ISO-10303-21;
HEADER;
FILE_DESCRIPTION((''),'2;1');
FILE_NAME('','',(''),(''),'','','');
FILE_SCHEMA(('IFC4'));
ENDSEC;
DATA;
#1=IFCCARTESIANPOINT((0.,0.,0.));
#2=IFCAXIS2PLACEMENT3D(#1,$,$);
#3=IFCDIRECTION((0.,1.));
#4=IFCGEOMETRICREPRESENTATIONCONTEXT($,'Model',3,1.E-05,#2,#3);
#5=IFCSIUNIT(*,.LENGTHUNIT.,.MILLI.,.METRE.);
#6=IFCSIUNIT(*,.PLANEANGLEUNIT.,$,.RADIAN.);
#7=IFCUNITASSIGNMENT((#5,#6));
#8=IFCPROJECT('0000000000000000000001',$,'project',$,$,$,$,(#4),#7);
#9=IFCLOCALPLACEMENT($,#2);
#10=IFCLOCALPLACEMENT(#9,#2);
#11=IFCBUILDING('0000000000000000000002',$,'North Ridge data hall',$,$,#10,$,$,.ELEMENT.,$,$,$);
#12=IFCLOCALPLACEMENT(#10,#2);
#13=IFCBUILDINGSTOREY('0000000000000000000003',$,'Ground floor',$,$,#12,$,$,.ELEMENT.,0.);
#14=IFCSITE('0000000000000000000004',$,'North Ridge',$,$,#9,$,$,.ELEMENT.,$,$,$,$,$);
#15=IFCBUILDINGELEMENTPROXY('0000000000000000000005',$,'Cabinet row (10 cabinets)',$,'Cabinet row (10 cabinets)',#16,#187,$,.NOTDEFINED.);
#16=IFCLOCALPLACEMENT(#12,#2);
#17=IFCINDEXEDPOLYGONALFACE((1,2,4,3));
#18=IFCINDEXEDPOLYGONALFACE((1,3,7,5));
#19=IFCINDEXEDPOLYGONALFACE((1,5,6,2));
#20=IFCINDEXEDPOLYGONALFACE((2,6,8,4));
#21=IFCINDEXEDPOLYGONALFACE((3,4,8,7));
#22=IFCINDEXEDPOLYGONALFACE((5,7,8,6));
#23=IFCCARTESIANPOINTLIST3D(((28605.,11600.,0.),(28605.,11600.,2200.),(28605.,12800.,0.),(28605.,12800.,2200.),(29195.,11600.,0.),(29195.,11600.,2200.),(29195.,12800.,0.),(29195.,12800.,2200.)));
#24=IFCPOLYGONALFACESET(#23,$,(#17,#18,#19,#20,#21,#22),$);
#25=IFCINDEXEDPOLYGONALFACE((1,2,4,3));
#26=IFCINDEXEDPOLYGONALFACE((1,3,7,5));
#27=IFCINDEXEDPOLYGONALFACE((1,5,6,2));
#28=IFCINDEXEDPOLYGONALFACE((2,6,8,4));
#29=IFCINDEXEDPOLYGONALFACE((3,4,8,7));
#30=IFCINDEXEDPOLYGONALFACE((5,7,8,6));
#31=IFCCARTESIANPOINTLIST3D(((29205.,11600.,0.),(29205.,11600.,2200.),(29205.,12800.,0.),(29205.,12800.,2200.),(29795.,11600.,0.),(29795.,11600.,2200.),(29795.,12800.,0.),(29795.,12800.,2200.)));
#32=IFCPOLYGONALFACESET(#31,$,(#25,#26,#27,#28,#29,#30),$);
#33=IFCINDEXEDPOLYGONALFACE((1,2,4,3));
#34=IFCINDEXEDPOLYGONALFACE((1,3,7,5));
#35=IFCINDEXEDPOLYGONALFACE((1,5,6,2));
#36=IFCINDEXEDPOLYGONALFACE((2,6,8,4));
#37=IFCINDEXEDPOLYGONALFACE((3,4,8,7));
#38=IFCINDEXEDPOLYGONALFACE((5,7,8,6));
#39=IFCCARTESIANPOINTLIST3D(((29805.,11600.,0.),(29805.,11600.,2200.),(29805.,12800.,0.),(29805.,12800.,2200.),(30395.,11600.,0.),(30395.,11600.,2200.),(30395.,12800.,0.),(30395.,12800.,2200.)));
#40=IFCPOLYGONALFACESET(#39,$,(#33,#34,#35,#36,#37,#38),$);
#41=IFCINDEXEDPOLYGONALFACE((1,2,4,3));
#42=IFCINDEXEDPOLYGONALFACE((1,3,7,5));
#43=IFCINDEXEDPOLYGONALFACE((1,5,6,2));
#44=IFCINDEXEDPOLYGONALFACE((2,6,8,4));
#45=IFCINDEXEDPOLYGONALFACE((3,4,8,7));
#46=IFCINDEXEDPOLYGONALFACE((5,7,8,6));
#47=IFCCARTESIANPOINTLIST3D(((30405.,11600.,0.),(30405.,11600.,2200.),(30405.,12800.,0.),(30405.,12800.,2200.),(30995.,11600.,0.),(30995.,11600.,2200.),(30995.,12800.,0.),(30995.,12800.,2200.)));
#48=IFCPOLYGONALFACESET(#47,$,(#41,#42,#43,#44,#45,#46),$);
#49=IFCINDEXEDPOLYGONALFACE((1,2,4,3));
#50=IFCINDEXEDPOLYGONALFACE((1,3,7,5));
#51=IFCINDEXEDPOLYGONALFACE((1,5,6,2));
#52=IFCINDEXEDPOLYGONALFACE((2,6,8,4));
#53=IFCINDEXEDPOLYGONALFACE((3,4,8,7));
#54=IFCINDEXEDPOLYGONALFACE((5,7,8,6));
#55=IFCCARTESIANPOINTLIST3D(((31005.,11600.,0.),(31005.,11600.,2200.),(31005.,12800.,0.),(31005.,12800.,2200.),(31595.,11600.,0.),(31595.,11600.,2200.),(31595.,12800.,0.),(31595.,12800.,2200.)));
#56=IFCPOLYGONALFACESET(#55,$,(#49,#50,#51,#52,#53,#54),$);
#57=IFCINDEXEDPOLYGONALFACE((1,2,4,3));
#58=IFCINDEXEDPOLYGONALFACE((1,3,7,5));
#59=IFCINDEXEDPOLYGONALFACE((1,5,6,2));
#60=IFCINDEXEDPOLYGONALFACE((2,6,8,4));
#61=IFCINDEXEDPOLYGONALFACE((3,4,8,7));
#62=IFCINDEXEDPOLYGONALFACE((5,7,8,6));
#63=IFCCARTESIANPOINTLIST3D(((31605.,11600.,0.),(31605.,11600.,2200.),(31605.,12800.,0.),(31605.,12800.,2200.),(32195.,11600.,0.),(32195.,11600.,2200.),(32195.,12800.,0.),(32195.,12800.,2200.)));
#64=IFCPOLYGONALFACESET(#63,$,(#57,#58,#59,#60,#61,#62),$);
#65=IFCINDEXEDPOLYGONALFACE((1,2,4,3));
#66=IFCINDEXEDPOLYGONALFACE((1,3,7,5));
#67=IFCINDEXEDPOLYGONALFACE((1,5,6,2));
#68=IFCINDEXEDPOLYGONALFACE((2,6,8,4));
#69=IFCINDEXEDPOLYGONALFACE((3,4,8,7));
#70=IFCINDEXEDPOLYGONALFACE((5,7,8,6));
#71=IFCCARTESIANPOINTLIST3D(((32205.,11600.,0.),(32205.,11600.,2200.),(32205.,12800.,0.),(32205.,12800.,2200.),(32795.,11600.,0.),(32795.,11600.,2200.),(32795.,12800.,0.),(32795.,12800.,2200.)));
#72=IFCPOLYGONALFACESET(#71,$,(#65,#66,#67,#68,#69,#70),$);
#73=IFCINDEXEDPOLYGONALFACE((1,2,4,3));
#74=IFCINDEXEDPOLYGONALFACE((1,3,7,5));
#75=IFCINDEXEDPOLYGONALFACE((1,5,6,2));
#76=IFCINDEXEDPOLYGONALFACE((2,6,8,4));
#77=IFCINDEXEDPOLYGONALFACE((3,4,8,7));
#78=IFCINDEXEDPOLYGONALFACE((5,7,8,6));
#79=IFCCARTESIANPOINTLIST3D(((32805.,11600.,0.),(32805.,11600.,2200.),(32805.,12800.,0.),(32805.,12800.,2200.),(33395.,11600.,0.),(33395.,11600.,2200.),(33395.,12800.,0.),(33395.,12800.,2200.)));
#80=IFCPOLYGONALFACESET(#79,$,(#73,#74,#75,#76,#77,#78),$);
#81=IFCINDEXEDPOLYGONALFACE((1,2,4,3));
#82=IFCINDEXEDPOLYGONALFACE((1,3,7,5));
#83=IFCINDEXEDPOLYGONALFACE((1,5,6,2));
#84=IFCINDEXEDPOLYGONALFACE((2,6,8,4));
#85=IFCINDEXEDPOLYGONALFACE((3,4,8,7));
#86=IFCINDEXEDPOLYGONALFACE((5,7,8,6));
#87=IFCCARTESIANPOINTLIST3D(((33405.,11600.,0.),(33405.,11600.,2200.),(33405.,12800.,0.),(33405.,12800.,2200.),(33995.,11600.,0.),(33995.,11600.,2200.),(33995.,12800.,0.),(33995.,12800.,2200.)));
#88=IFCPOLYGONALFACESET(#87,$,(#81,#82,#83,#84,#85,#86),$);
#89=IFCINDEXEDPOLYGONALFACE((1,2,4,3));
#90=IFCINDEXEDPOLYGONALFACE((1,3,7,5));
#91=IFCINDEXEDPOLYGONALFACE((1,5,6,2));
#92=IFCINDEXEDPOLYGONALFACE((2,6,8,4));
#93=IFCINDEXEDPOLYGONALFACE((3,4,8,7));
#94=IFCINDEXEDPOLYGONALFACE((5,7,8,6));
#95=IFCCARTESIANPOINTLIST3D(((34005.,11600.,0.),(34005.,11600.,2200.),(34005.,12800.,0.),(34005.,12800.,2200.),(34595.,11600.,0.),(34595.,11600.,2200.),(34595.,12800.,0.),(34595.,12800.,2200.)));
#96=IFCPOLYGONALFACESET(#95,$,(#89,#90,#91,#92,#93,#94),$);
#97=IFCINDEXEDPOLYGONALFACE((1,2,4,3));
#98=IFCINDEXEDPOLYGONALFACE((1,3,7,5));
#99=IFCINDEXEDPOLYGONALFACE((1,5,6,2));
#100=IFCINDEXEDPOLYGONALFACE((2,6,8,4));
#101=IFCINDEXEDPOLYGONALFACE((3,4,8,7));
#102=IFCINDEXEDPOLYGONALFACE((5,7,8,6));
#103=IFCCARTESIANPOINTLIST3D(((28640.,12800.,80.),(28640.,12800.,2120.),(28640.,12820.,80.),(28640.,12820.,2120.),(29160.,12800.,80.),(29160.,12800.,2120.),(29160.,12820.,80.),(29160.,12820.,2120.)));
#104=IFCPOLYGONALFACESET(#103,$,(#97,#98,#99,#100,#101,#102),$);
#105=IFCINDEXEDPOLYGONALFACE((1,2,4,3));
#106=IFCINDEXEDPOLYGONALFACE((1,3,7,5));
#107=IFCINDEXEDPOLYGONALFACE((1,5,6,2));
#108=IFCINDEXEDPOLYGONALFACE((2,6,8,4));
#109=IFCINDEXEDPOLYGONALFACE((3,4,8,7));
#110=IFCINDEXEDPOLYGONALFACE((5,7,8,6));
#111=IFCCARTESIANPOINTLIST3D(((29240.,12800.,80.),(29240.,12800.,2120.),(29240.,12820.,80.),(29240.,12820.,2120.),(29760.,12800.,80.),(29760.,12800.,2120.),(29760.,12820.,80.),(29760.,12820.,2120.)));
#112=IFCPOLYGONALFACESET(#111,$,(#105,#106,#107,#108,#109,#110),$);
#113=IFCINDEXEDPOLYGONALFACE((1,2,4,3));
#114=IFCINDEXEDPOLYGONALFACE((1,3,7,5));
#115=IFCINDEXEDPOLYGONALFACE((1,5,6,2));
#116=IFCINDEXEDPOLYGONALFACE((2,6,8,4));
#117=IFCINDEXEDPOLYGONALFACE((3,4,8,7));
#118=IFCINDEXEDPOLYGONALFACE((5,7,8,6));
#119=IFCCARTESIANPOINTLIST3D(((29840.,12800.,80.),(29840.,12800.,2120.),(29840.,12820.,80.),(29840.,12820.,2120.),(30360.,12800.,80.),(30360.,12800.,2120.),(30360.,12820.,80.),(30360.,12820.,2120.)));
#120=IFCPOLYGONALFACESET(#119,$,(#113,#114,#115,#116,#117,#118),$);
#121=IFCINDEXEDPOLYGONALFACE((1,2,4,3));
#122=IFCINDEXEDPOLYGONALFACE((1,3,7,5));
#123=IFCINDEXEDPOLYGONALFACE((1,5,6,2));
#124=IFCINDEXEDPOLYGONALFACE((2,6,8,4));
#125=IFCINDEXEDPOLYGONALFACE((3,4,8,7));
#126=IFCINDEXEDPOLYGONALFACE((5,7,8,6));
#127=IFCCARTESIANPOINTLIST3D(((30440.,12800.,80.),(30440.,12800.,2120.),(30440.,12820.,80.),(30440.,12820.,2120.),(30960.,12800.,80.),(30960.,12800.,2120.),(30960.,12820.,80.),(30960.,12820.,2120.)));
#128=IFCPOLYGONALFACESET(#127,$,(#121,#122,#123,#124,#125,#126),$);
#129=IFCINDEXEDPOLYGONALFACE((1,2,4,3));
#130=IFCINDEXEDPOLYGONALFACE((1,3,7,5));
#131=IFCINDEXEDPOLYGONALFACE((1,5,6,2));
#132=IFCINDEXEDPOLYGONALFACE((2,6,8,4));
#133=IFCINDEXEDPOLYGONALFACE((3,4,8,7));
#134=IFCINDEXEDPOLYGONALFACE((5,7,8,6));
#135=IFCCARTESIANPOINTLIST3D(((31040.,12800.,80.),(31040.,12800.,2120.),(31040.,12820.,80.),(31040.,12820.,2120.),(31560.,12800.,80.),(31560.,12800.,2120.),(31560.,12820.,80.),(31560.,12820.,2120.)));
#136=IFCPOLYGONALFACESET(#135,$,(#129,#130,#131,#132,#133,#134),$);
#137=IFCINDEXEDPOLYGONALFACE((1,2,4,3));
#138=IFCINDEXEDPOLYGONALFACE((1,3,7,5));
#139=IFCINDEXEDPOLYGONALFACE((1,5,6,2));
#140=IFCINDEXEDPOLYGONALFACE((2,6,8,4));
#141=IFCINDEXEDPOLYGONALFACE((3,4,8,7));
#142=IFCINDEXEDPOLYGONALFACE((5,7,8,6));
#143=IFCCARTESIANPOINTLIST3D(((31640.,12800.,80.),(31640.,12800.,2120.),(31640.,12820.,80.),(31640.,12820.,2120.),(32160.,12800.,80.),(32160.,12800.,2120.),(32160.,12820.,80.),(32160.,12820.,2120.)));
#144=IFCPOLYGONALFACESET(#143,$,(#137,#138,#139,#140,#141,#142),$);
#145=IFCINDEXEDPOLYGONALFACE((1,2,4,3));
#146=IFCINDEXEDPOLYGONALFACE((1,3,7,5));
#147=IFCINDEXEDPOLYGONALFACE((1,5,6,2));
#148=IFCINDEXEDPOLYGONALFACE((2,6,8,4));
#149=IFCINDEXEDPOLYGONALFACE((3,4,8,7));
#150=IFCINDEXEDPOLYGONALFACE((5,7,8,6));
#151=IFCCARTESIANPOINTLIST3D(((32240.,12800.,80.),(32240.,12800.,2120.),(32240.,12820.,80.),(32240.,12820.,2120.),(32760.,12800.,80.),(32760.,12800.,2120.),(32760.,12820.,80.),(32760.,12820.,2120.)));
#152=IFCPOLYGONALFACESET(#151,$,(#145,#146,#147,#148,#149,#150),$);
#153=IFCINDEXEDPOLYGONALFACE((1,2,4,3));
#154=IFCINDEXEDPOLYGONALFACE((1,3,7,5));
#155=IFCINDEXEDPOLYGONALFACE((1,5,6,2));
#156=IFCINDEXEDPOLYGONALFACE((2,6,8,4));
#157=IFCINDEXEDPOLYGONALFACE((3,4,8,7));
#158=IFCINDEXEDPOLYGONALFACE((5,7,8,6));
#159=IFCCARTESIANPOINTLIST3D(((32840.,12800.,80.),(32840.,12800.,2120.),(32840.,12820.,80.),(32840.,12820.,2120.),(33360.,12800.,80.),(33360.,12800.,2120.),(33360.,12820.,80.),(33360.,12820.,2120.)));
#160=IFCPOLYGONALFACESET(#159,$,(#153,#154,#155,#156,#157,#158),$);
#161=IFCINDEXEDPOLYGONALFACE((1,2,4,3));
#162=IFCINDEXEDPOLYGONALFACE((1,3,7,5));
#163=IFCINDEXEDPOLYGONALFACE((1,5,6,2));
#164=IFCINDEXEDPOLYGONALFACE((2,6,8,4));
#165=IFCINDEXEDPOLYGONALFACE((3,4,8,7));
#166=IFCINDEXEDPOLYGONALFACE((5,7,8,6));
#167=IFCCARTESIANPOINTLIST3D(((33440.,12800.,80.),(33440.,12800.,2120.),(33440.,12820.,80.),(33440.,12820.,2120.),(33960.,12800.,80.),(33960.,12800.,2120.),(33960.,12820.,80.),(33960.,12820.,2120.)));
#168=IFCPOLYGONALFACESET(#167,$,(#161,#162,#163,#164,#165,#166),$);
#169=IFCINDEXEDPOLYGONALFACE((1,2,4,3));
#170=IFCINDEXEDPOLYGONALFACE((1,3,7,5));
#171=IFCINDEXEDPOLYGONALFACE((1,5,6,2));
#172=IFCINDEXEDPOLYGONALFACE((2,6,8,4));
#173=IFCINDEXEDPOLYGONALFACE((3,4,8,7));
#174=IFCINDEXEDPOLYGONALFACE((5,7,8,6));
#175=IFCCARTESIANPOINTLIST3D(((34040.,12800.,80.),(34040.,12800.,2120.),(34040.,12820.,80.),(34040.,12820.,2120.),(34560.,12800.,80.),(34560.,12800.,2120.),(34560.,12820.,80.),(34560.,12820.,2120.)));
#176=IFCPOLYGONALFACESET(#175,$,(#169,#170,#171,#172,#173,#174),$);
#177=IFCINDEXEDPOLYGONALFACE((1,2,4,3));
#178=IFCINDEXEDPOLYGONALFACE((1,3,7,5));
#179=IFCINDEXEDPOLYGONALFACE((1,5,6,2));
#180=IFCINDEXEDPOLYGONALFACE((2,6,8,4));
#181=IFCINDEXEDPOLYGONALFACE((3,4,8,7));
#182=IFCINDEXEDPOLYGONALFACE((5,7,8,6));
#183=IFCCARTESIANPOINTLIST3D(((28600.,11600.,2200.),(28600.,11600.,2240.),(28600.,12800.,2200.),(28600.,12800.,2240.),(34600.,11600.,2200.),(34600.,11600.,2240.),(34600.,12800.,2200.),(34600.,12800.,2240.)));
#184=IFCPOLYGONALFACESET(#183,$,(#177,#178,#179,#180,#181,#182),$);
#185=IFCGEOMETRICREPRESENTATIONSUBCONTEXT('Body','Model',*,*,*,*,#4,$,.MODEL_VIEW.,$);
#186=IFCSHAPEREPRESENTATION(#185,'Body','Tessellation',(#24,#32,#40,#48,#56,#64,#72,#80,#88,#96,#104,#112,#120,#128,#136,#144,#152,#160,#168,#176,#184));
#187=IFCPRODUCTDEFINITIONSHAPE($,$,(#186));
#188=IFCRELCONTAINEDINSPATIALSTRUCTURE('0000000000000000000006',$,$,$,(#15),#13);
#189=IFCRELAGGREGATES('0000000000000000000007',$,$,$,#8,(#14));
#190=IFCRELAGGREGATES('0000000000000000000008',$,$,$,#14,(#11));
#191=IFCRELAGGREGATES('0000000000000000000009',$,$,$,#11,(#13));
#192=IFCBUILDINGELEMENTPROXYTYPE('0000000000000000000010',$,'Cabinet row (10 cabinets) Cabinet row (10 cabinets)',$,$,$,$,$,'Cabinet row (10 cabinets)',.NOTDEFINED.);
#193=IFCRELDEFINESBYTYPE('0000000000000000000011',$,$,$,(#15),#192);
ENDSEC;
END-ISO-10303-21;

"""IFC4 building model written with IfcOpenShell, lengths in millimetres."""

from ifc_helpers import new_model, si_unit, direction, frame, origin, place, context, subcontext, project, spatial, polyline, outline, extrude, source, transform, mapped, type_object, type_shapes, element, save


model = new_model("IFC4")

# Units and contexts
model_context = context("Model", 3, precision=1e-05, world=origin(), true_north=direction((0.0, 1.0)))
body_context = subcontext(model_context, "Body", "Model", "MODEL_VIEW")
ifc_project = project(units=[si_unit("LENGTHUNIT", "METRE", prefix="MILLI"), si_unit("PLANEANGLEUNIT", "RADIAN")], contexts=[model_context])

# Site, building, storey
site_placement = place(None, origin())
site = spatial("IfcSite", under=ifc_project, at=site_placement, Name="North Ridge", CompositionType="ELEMENT")
building_placement = place(site_placement, origin())
building = spatial("IfcBuilding", under=site, at=building_placement, Name="North Ridge data hall", CompositionType="ELEMENT")
storey_placement = place(building_placement, origin())
storey = spatial("IfcBuildingStorey", under=building, at=storey_placement, Name="Ground floor", CompositionType="ELEMENT", Elevation=0.0)

# Building element proxy
building_element_proxy_type_1 = type_object("IfcBuildingElementProxyType", Name="Cabinet row (10 cabinets) Cabinet row (10 cabinets)", ElementType="Cabinet row (10 cabinets)", PredefinedType="NOTDEFINED")
shared_shape_1 = source(origin(), body_context, "Body", "SweptSolid", [
    extrude(outline(polyline([(5.0, 0.0), (595.0, 0.0), (595.0, 1200.0), (5.0, 1200.0), (5.0, 0.0)])), origin(), (0.0, 0.0, 1.0), 2200.0),
    extrude(outline(polyline([(605.0, 0.0), (1195.0, 0.0), (1195.0, 1200.0), (605.0, 1200.0), (605.0, 0.0)])), origin(), (0.0, 0.0, 1.0), 2200.0),
    extrude(outline(polyline([(1205.0, 0.0), (1795.0, 0.0), (1795.0, 1200.0), (1205.0, 1200.0), (1205.0, 0.0)])), origin(), (0.0, 0.0, 1.0), 2200.0),
    extrude(outline(polyline([(1805.0, 0.0), (2395.0, 0.0), (2395.0, 1200.0), (1805.0, 1200.0), (1805.0, 0.0)])), origin(), (0.0, 0.0, 1.0), 2200.0),
    extrude(outline(polyline([(2405.0, 0.0), (2995.0, 0.0), (2995.0, 1200.0), (2405.0, 1200.0), (2405.0, 0.0)])), origin(), (0.0, 0.0, 1.0), 2200.0),
    extrude(outline(polyline([(3005.0, 0.0), (3595.0, 0.0), (3595.0, 1200.0), (3005.0, 1200.0), (3005.0, 0.0)])), origin(), (0.0, 0.0, 1.0), 2200.0),
    extrude(outline(polyline([(3605.0, 0.0), (4195.0, 0.0), (4195.0, 1200.0), (3605.0, 1200.0), (3605.0, 0.0)])), origin(), (0.0, 0.0, 1.0), 2200.0),
    extrude(outline(polyline([(4205.0, 0.0), (4795.0, 0.0), (4795.0, 1200.0), (4205.0, 1200.0), (4205.0, 0.0)])), origin(), (0.0, 0.0, 1.0), 2200.0),
    extrude(outline(polyline([(4805.0, 0.0), (5395.0, 0.0), (5395.0, 1200.0), (4805.0, 1200.0), (4805.0, 0.0)])), origin(), (0.0, 0.0, 1.0), 2200.0),
    extrude(outline(polyline([(5405.0, 0.0), (5995.0, 0.0), (5995.0, 1200.0), (5405.0, 1200.0), (5405.0, 0.0)])), origin(), (0.0, 0.0, 1.0), 2200.0),
    extrude(outline(polyline([(40.0, 1200.0), (560.0, 1200.0), (560.0, 1220.0), (40.0, 1220.0), (40.0, 1200.0)])), frame((0.0, 0.0, 80.0)), (0.0, 0.0, 1.0), 2040.0),
    extrude(outline(polyline([(640.0, 1200.0), (1160.0, 1200.0), (1160.0, 1220.0), (640.0, 1220.0), (640.0, 1200.0)])), frame((0.0, 0.0, 80.0)), (0.0, 0.0, 1.0), 2040.0),
    extrude(outline(polyline([(1240.0, 1200.0), (1760.0, 1200.0), (1760.0, 1220.0), (1240.0, 1220.0), (1240.0, 1200.0)])), frame((0.0, 0.0, 80.0)), (0.0, 0.0, 1.0), 2040.0),
    extrude(outline(polyline([(1840.0, 1200.0), (2360.0, 1200.0), (2360.0, 1220.0), (1840.0, 1220.0), (1840.0, 1200.0)])), frame((0.0, 0.0, 80.0)), (0.0, 0.0, 1.0), 2040.0),
    extrude(outline(polyline([(2440.0, 1200.0), (2960.0, 1200.0), (2960.0, 1220.0), (2440.0, 1220.0), (2440.0, 1200.0)])), frame((0.0, 0.0, 80.0)), (0.0, 0.0, 1.0), 2040.0),
    extrude(outline(polyline([(3040.0, 1200.0), (3560.0, 1200.0), (3560.0, 1220.0), (3040.0, 1220.0), (3040.0, 1200.0)])), frame((0.0, 0.0, 80.0)), (0.0, 0.0, 1.0), 2040.0),
    extrude(outline(polyline([(3640.0, 1200.0), (4160.0, 1200.0), (4160.0, 1220.0), (3640.0, 1220.0), (3640.0, 1200.0)])), frame((0.0, 0.0, 80.0)), (0.0, 0.0, 1.0), 2040.0),
    extrude(outline(polyline([(4240.0, 1200.0), (4760.0, 1200.0), (4760.0, 1220.0), (4240.0, 1220.0), (4240.0, 1200.0)])), frame((0.0, 0.0, 80.0)), (0.0, 0.0, 1.0), 2040.0),
    extrude(outline(polyline([(4840.0, 1200.0), (5360.0, 1200.0), (5360.0, 1220.0), (4840.0, 1220.0), (4840.0, 1200.0)])), frame((0.0, 0.0, 80.0)), (0.0, 0.0, 1.0), 2040.0),
    extrude(outline(polyline([(5440.0, 1200.0), (5960.0, 1200.0), (5960.0, 1220.0), (5440.0, 1220.0), (5440.0, 1200.0)])), frame((0.0, 0.0, 80.0)), (0.0, 0.0, 1.0), 2040.0),
    extrude(outline(polyline([(0.0, 0.0), (6000.0, 0.0), (6000.0, 1200.0), (0.0, 1200.0), (0.0, 0.0)])), frame((0.0, 0.0, 2200.0)), (0.0, 0.0, 1.0), 40.0),
])
type_shapes(building_element_proxy_type_1, [shared_shape_1])
for number, where, z_axis, x_axis, name in (
    (1, (28600.0, 11600.0, 0.0), (0.0, 0.0, 1.0), (1.0, 0.0, 0.0), "Cabinet row (10 cabinets)"),
):
    element("IfcBuildingElementProxy", number, at=place(storey_placement, frame(where, z_axis=z_axis, x_axis=x_axis)), inside=storey, type_object=building_element_proxy_type_1, Name=name, ObjectType="Cabinet row (10 cabinets)", PredefinedType="NOTDEFINED", context=body_context, shape_type="MappedRepresentation", body=[
        mapped(shared_shape_1, transform((0.0, 0.0, 0.0))),
    ])

save(model, "model.ifc")
